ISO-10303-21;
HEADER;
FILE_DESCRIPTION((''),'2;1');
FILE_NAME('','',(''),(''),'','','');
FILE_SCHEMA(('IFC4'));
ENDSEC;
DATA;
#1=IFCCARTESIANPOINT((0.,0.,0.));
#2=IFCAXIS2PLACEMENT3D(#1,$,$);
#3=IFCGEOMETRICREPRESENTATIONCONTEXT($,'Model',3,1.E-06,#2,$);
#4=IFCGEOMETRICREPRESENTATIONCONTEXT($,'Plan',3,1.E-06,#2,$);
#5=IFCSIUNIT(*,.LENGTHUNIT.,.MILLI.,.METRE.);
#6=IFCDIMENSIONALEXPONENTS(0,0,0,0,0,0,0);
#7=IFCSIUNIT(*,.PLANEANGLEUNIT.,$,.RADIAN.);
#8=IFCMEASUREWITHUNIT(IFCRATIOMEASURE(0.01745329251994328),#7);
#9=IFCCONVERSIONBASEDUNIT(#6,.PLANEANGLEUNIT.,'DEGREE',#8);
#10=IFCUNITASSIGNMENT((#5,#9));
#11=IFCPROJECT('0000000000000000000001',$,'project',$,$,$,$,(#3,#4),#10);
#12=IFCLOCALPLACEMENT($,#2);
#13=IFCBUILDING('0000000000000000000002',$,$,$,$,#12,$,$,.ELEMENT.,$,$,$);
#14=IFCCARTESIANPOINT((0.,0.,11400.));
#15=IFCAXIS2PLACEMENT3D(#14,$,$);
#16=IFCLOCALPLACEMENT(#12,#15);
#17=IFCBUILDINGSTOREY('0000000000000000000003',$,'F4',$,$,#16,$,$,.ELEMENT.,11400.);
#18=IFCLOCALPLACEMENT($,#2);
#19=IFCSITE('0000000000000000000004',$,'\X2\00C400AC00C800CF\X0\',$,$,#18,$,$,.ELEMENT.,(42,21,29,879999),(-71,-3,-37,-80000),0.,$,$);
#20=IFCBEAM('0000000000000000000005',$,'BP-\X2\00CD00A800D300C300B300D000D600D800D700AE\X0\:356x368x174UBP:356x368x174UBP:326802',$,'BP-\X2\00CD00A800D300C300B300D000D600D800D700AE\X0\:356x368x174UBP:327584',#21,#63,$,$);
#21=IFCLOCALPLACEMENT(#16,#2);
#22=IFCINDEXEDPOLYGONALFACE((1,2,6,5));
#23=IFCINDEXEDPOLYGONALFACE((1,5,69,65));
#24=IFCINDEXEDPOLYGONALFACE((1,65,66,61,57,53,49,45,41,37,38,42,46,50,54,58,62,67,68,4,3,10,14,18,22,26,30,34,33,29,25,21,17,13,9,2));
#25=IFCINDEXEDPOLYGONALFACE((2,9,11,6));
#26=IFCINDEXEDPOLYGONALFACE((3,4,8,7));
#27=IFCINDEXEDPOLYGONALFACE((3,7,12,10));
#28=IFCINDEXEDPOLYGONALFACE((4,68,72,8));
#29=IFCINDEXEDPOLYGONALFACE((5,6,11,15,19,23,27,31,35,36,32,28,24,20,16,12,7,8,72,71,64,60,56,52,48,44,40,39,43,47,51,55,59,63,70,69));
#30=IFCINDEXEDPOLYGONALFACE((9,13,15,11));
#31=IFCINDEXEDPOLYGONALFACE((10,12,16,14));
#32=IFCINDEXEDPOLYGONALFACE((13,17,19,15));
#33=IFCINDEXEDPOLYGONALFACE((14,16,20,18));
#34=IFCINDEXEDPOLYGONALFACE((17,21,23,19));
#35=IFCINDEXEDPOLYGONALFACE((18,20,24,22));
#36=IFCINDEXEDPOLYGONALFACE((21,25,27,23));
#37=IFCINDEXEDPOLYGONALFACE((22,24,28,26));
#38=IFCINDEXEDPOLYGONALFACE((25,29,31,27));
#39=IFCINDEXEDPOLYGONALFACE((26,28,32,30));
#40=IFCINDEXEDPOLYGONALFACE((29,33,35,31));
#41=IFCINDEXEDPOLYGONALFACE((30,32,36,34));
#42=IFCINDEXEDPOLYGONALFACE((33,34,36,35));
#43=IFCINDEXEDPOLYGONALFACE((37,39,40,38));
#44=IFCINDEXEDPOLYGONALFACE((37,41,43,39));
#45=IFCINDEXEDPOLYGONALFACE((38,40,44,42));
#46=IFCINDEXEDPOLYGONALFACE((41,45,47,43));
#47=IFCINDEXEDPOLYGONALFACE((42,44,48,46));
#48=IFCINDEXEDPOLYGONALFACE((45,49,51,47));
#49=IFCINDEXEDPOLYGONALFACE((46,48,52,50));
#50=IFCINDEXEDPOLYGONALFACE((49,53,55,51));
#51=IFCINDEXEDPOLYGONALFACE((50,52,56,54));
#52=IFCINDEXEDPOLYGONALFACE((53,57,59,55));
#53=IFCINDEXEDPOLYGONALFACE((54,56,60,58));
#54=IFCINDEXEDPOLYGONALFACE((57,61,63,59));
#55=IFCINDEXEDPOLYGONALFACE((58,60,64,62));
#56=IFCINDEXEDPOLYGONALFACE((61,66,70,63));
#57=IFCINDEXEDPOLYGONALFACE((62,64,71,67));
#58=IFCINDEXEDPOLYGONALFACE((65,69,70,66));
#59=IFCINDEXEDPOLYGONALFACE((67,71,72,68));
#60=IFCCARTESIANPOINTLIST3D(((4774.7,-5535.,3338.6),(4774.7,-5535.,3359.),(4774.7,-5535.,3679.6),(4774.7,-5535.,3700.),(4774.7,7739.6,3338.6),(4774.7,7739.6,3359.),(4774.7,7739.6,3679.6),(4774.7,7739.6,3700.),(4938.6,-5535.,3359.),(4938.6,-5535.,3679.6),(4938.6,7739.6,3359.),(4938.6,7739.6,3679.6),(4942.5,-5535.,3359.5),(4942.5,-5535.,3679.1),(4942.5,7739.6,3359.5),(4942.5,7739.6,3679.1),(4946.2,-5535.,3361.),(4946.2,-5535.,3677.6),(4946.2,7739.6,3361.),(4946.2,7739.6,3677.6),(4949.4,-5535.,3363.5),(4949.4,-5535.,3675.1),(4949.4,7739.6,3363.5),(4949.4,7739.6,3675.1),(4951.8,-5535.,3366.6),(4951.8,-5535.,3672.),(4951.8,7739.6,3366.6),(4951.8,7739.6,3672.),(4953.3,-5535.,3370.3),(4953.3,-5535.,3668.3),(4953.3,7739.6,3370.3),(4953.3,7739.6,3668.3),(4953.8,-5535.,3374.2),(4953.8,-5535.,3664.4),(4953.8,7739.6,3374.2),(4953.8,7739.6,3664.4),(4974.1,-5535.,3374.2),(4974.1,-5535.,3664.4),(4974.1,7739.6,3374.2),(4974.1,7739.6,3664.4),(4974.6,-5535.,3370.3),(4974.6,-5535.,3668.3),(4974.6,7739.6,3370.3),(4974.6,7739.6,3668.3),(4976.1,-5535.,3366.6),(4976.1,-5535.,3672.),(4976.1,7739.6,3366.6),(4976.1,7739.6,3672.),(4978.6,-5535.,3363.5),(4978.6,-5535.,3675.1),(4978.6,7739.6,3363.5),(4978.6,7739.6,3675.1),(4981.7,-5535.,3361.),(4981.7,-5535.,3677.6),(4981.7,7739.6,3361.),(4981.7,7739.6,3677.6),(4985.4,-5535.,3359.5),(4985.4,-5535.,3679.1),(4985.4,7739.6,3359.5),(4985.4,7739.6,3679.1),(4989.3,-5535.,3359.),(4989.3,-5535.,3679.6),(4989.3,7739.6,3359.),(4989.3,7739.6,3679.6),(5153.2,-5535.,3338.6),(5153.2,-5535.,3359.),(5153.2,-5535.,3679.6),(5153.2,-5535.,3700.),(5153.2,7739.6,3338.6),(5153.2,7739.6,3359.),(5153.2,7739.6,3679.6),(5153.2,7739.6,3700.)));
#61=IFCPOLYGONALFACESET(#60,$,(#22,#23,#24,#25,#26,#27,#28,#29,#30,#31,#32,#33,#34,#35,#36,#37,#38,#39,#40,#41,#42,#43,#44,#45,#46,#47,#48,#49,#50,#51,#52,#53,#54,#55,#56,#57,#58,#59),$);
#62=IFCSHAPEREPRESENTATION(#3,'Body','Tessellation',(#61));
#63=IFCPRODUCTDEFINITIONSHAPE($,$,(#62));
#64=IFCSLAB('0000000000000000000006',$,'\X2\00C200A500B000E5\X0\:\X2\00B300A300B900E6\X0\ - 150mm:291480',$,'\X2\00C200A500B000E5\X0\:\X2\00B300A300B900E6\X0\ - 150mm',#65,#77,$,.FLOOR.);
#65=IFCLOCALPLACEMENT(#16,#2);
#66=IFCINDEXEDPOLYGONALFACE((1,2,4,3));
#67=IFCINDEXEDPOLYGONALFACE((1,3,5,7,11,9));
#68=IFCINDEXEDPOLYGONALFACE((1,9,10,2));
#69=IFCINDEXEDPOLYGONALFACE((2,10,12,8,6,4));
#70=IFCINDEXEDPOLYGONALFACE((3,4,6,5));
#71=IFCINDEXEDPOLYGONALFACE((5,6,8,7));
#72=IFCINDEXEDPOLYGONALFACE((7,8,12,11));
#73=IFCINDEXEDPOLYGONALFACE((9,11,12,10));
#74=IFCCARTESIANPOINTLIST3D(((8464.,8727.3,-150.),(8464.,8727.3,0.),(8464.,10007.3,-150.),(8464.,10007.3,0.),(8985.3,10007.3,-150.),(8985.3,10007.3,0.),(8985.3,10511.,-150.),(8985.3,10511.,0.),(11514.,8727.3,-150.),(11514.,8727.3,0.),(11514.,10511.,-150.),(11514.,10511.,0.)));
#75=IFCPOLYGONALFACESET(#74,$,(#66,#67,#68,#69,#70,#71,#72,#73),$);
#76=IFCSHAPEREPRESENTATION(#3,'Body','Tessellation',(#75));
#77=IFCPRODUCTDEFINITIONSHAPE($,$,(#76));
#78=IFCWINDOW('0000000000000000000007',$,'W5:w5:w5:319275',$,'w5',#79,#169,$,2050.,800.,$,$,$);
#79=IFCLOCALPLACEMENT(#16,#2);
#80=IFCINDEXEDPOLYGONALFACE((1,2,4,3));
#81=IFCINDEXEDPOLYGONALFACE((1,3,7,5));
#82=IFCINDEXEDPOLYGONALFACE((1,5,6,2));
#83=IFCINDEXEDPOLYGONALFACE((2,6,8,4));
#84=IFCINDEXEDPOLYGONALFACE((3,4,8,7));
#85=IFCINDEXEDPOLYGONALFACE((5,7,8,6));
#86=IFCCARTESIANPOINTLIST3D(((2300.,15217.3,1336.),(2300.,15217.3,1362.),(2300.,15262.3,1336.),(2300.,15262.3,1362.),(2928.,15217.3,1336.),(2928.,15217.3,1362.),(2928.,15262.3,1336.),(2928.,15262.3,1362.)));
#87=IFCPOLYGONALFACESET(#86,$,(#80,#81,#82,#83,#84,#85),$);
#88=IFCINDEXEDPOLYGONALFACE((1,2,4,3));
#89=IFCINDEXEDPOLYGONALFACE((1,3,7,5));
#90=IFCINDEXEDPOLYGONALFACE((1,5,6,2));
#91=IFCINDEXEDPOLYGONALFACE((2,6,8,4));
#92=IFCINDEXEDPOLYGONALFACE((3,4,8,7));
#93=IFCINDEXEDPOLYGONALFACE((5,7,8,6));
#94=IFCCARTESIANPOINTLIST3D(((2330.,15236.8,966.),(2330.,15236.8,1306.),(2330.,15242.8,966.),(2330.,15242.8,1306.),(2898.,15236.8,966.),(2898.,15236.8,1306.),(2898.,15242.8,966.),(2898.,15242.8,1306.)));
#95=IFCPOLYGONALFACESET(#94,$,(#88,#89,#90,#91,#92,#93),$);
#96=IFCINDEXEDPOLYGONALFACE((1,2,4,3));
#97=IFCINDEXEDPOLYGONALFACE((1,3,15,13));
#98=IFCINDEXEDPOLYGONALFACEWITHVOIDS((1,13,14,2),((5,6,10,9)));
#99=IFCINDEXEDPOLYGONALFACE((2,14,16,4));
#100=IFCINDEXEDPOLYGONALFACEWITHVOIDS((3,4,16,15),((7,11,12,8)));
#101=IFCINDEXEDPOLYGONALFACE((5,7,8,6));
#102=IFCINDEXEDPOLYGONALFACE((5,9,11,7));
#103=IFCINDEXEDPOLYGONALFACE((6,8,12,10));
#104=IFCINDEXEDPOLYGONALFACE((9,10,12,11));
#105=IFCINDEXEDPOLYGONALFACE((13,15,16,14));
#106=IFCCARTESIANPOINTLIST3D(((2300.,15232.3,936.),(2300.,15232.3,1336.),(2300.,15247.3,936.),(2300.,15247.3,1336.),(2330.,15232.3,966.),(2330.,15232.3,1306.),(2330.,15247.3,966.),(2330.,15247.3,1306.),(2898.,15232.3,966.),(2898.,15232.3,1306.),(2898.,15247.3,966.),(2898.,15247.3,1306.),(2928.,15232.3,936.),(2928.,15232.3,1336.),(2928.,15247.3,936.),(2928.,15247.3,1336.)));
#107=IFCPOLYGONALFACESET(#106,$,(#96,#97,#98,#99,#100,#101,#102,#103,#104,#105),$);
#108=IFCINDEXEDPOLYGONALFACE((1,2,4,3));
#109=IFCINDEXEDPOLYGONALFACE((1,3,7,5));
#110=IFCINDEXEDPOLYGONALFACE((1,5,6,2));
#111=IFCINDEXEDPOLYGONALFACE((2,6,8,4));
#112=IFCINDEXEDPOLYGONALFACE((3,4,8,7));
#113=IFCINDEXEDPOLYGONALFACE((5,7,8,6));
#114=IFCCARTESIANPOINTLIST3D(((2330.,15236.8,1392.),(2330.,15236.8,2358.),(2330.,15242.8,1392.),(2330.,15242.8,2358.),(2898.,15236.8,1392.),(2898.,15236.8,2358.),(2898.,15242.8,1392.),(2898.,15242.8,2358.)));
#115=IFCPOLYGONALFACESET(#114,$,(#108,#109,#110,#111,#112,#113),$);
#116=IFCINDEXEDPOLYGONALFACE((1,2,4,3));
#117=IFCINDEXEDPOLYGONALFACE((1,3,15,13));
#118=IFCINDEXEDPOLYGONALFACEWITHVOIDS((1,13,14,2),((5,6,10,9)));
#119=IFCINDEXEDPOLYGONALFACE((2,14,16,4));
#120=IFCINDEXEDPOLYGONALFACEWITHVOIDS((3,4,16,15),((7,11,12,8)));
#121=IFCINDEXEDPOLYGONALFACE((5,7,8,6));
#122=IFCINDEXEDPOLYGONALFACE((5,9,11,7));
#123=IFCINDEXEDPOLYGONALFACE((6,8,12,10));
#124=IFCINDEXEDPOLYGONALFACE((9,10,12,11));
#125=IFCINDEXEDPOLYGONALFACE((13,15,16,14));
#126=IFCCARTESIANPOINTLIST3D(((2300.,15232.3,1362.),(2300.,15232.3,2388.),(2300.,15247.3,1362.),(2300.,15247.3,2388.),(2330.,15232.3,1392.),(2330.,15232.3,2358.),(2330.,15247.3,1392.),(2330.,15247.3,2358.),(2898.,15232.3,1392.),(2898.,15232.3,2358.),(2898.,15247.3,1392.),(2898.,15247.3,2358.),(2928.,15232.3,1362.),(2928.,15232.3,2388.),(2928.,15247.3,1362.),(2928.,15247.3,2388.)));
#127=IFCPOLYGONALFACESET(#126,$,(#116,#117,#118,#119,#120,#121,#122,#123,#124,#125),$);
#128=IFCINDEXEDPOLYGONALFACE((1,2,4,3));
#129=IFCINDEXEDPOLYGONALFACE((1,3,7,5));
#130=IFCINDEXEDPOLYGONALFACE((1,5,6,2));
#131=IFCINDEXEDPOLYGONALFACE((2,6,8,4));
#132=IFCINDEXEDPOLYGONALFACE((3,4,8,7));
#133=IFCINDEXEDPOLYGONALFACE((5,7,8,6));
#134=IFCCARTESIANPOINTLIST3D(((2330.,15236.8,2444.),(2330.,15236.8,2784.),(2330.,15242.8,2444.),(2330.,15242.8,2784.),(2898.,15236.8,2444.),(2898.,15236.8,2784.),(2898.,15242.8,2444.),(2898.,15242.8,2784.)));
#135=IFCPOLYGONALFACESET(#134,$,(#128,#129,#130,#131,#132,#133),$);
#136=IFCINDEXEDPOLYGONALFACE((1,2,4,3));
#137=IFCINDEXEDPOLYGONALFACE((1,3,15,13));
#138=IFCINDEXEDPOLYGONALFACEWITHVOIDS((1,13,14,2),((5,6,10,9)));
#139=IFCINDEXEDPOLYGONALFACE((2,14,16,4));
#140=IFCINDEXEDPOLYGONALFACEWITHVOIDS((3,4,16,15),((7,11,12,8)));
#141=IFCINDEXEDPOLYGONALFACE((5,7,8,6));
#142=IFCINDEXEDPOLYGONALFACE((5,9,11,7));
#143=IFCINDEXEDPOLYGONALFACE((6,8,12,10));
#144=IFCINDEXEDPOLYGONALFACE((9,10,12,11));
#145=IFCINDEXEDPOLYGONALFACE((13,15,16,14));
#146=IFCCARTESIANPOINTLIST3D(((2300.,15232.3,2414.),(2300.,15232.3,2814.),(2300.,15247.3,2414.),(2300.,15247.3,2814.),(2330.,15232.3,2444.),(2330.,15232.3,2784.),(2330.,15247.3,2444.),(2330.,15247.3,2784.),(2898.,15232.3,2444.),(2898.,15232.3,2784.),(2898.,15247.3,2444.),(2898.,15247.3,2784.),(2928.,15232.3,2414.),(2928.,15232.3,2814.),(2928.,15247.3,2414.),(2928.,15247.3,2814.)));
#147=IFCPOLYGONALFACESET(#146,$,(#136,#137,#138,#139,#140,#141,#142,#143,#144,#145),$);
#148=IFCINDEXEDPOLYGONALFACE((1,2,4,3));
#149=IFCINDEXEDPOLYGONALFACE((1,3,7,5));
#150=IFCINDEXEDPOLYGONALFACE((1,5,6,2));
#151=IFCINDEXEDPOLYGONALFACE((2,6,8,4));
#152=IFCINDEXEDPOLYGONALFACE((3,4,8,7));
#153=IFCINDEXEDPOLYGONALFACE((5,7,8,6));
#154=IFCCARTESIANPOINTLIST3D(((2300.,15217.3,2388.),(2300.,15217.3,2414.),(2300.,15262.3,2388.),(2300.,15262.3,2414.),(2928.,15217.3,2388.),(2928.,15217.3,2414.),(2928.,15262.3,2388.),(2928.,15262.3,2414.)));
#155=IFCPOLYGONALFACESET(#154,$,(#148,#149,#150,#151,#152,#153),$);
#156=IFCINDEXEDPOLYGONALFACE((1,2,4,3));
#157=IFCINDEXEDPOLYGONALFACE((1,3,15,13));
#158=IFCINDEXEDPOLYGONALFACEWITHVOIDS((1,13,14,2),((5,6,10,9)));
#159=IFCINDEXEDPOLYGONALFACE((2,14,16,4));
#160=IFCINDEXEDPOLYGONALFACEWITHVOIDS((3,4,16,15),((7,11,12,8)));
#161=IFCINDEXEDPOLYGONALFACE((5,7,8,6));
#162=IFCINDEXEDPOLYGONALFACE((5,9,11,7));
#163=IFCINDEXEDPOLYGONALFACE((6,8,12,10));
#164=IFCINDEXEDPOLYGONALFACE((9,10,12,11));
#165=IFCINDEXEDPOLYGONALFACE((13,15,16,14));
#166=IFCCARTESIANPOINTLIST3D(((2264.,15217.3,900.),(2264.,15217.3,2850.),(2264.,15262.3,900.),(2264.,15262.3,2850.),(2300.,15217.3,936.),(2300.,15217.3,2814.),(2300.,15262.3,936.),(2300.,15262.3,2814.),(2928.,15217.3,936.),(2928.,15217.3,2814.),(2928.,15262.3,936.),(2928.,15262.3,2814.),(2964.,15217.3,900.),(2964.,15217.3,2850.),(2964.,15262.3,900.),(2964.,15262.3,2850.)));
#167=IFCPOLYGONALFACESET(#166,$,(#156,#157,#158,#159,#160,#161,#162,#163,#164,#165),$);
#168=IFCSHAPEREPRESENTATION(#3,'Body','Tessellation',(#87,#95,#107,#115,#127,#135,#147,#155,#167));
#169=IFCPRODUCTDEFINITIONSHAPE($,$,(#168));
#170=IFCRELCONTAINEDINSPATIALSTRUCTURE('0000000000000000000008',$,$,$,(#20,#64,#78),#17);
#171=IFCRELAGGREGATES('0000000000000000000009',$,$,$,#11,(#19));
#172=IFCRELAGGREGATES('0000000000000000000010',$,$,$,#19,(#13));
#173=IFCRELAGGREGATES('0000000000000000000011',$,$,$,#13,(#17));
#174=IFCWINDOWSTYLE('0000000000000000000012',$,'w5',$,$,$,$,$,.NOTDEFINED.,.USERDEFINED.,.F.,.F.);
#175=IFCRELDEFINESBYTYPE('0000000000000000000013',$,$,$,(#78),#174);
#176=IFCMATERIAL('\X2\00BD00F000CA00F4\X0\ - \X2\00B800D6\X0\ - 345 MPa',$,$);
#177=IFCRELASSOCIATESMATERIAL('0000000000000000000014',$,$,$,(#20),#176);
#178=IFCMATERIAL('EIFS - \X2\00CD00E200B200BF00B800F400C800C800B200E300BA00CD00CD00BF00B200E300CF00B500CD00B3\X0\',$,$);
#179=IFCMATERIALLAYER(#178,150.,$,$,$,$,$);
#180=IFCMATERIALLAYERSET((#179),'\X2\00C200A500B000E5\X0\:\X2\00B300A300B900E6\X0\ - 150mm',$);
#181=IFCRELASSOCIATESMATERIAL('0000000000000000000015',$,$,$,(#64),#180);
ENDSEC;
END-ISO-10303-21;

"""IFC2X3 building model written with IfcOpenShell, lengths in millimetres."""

from ifc_helpers import new_model, entity, si_unit, converted_unit, frame, frame_2d, origin, origin_2d_with_axis, place, context, project, spatial, polyline, circle_curve, parameter, trimmed, segment, composite_curve, rectangle, outline, extrude, source, transform, mapped, material, layer, layer_set, layer_usage, type_object, type_shapes, element, save


model = new_model("IFC2X3")

# Units and contexts
model_context = context("Model", 3, precision=1e-06, world=origin())
plan_context = context("Plan", 3, precision=1e-06, world=origin())
ifc_project = project(units=[si_unit("LENGTHUNIT", "METRE", prefix="MILLI"), converted_unit("PLANEANGLEUNIT", "DEGREE", entity("IfcRatioMeasure", 0.01745329251994328), si_unit("PLANEANGLEUNIT", "RADIAN"), dimensions=[0, 0, 0, 0, 0, 0, 0])], contexts=[model_context, plan_context])

# Site, building, storey
site_placement = place(None, origin())
site = spatial("IfcSite", under=ifc_project, at=site_placement, Name="Ä¬ÈÏ", CompositionType="ELEMENT", RefLatitude=(42, 21, 29, 879999), RefLongitude=(-71, -3, -37, -80000), RefElevation=0.0)
building_placement = place(None, origin())
building = spatial("IfcBuilding", under=site, at=building_placement, CompositionType="ELEMENT")
storey_placement = place(building_placement, frame((0.0, 0.0, 11400.0)))
storey = spatial("IfcBuildingStorey", under=building, at=storey_placement, Name="F4", CompositionType="ELEMENT", Elevation=11400.0)

# Beam
ifc_material_1 = material(Name="½ðÊô - ¸Ö - 345 MPa")
beam_1_placement = place(storey_placement, frame((4964.0, 7977.3, 3700.0), z_axis=(0.0, 0.0, 1.0), x_axis=(-1.0, 0.0, 0.0)))
element("IfcBeam", 1, at=beam_1_placement, inside=storey, material=ifc_material_1, Name="BP-Í¨ÓÃ³ÐÖØ×®:356x368x174UBP:356x368x174UBP:326802", ObjectType="BP-Í¨ÓÃ³ÐÖØ×®:356x368x174UBP:327584", context=model_context, shape_type="SweptSolid", body=[
    extrude(outline(composite_curve([segment(polyline([(160.3, -189.3), (180.7, -189.3)]), True, "CONTINUOUS"), segment(polyline([(180.7, -189.3), (180.7, 189.2)]), True, "CONTINUOUS"), segment(polyline([(180.7, 189.2), (160.3, 189.2)]), True, "CONTINUOUS"), segment(polyline([(160.3, 189.2), (160.3, 25.3)]), True, "CONTINUOUS"), segment(trimmed(circle_curve(frame_2d((145.1, 25.3), x_axis=(1.0, 0.0)), 15.2), [parameter(270.0)], [parameter(0.0)], True, "PARAMETER"), False, "CONTINUOUS"), segment(polyline([(145.1, 10.1), (-145.1, 10.1)]), True, "CONTINUOUS"), segment(trimmed(circle_curve(frame_2d((-145.1, 25.3), x_axis=(0.0, -1.0)), 15.2), [parameter(270.0)], [parameter(360.0)], True, "PARAMETER"), False, "CONTINUOUS"), segment(polyline([(-160.3, 25.3), (-160.3, 189.2)]), True, "CONTINUOUS"), segment(polyline([(-160.3, 189.2), (-180.7, 189.2)]), True, "CONTINUOUS"), segment(polyline([(-180.7, 189.2), (-180.7, -189.3)]), True, "CONTINUOUS"), segment(polyline([(-180.7, -189.3), (-160.3, -189.3)]), True, "CONTINUOUS"), segment(polyline([(-160.3, -189.3), (-160.3, -25.4)]), True, "CONTINUOUS"), segment(trimmed(circle_curve(frame_2d((-145.1, -25.4), x_axis=(-1.0, 0.0)), 15.2), [parameter(270.0)], [parameter(0.0)], True, "PARAMETER"), False, "CONTINUOUS"), segment(polyline([(-145.1, -10.2), (145.1, -10.2)]), True, "CONTINUOUS"), segment(trimmed(circle_curve(frame_2d((145.1, -25.4), x_axis=(0.0, 1.0)), 15.2), [parameter(270.0)], [parameter(0.0)], True, "PARAMETER"), False, "CONTINUOUS"), segment(polyline([(160.3, -25.4), (160.3, -189.3)]), True, "CONTINUOUS")], self_intersect=False)), frame((0.0, 13512.3, -180.7), z_axis=(0.0, -1.0, 0.0), x_axis=(0.0, 0.0, -1.0)), (0.0, 0.0, 1.0), 13274.6),
])

# Slab
ifc_material_2 = material(Name="EIFS - Íâ²¿¸ôÈÈ²ãºÍÍ¿²ãÏµÍ³")
ifc_layer_1 = layer(ifc_material_2, 150.0)
ifc_layer_set_1 = layer_set([ifc_layer_1], Name="Â¥°å:³£¹æ - 150mm")
ifc_layer_usage_1 = layer_usage(ifc_layer_set_1, "AXIS3", "POSITIVE", 0.0)
slab_1_placement = place(storey_placement, frame((8464.0, 8727.3, -150.0)))
element("IfcSlab", 2, at=slab_1_placement, inside=storey, material=ifc_layer_usage_1, Name="Â¥°å:³£¹æ - 150mm:291480", ObjectType="Â¥°å:³£¹æ - 150mm", PredefinedType="FLOOR", context=model_context, shape_type="SweptSolid", body=[
    extrude(outline(polyline([(-8464.0, 8727.3), (-8464.0, 10007.3), (-8985.3, 10007.3), (-8985.3, 10511.0), (-11514.0, 10511.0), (-11514.0, 8727.3), (-8464.0, 8727.3)])), frame((-8464.0, -8727.3, 150.0), z_axis=(0.0, 0.0, -1.0), x_axis=(-1.0, 0.0, 0.0)), (0.0, 0.0, 1.0), 150.0),
])

# Window
window_style = type_object("IfcWindowStyle", Name="w5", ConstructionType="NOTDEFINED", OperationType="USERDEFINED", ParameterTakesPrecedence=False, Sizeable=False)
shared_shape = source(origin(), model_context, "Body", "SweptSolid", [
    extrude(rectangle(XDim=45.0, YDim=628.0, at=origin_2d_with_axis()), frame((350.0, -248.1, 436.0), z_axis=(0.0, 0.0, 1.0), x_axis=(0.0, 1.0, 0.0)), (0.0, 0.0, 1.0), 26.0),
    extrude(rectangle(XDim=6.0, YDim=568.0, at=origin_2d_with_axis()), frame((350.0, -248.1, 66.0), z_axis=(0.0, 0.0, 1.0), x_axis=(0.0, 1.0, 0.0)), (0.0, 0.0, 1.0), 340.0),
    extrude(outline(polyline([(-200.0, -314.0), (200.0, -314.0), (200.0, 314.0), (-200.0, 314.0), (-200.0, -314.0)]), holes=[polyline([(170.0, -284.0), (-170.0, -284.0), (-170.0, 284.0), (170.0, 284.0), (170.0, -284.0)])]), frame((350.0, -255.6, 236.0), z_axis=(0.0, 1.0, 0.0), x_axis=(0.0, 0.0, 1.0)), (0.0, 0.0, 1.0), 15.0),
    extrude(rectangle(XDim=6.0, YDim=568.0, at=origin_2d_with_axis()), frame((350.0, -248.1, 492.0), z_axis=(0.0, 0.0, 1.0), x_axis=(0.0, 1.0, 0.0)), (0.0, 0.0, 1.0), 966.0),
    extrude(outline(polyline([(-513.0, -314.0), (513.0, -314.0), (513.0, 314.0), (-513.0, 314.0), (-513.0, -314.0)]), holes=[polyline([(483.0, -284.0), (-483.0, -284.0), (-483.0, 284.0), (483.0, 284.0), (483.0, -284.0)])]), frame((350.0, -255.6, 975.0), z_axis=(0.0, 1.0, 0.0), x_axis=(0.0, 0.0, 1.0)), (0.0, 0.0, 1.0), 15.0),
    extrude(rectangle(XDim=6.0, YDim=568.0, at=origin_2d_with_axis()), frame((350.0, -248.1, 1544.0), z_axis=(0.0, 0.0, 1.0), x_axis=(0.0, 1.0, 0.0)), (0.0, 0.0, 1.0), 340.0),
    extrude(outline(polyline([(-200.0, -314.0), (200.0, -314.0), (200.0, 314.0), (-200.0, 314.0), (-200.0, -314.0)]), holes=[polyline([(170.0, -284.0), (-170.0, -284.0), (-170.0, 284.0), (170.0, 284.0), (170.0, -284.0)])]), frame((350.0, -255.6, 1714.0), z_axis=(0.0, 1.0, 0.0), x_axis=(0.0, 0.0, 1.0)), (0.0, 0.0, 1.0), 15.0),
    extrude(rectangle(XDim=45.0, YDim=628.0, at=origin_2d_with_axis()), frame((350.0, -248.1, 1488.0), z_axis=(0.0, 0.0, 1.0), x_axis=(0.0, 1.0, 0.0)), (0.0, 0.0, 1.0), 26.0),
    extrude(outline(polyline([(-975.0, -350.0), (975.0, -350.0), (975.0, 350.0), (-975.0, 350.0), (-975.0, -350.0)]), holes=[polyline([(939.0, -314.0), (-939.0, -314.0), (-939.0, 314.0), (939.0, 314.0), (939.0, -314.0)])]), frame((350.0, -270.6, 975.0), z_axis=(0.0, 1.0, 0.0), x_axis=(0.0, 0.0, 1.0)), (0.0, 0.0, 1.0), 45.0),
])
type_shapes(window_style, [shared_shape])
for number, where, name in (
    (3, (2264.0, 15487.9, 900.0), "W5:w5:w5:319275"),
):
    element("IfcWindow", number, at=place(storey_placement, frame(where)), inside=storey, type_object=window_style, Name=name, ObjectType="w5", OverallHeight=2050.0, OverallWidth=800.0, context=model_context, shape_type="MappedRepresentation", body=[
        mapped(shared_shape, transform((0.0, 0.0, 0.0), scale=1.0)),
    ])

save(model, "model.ifc")
